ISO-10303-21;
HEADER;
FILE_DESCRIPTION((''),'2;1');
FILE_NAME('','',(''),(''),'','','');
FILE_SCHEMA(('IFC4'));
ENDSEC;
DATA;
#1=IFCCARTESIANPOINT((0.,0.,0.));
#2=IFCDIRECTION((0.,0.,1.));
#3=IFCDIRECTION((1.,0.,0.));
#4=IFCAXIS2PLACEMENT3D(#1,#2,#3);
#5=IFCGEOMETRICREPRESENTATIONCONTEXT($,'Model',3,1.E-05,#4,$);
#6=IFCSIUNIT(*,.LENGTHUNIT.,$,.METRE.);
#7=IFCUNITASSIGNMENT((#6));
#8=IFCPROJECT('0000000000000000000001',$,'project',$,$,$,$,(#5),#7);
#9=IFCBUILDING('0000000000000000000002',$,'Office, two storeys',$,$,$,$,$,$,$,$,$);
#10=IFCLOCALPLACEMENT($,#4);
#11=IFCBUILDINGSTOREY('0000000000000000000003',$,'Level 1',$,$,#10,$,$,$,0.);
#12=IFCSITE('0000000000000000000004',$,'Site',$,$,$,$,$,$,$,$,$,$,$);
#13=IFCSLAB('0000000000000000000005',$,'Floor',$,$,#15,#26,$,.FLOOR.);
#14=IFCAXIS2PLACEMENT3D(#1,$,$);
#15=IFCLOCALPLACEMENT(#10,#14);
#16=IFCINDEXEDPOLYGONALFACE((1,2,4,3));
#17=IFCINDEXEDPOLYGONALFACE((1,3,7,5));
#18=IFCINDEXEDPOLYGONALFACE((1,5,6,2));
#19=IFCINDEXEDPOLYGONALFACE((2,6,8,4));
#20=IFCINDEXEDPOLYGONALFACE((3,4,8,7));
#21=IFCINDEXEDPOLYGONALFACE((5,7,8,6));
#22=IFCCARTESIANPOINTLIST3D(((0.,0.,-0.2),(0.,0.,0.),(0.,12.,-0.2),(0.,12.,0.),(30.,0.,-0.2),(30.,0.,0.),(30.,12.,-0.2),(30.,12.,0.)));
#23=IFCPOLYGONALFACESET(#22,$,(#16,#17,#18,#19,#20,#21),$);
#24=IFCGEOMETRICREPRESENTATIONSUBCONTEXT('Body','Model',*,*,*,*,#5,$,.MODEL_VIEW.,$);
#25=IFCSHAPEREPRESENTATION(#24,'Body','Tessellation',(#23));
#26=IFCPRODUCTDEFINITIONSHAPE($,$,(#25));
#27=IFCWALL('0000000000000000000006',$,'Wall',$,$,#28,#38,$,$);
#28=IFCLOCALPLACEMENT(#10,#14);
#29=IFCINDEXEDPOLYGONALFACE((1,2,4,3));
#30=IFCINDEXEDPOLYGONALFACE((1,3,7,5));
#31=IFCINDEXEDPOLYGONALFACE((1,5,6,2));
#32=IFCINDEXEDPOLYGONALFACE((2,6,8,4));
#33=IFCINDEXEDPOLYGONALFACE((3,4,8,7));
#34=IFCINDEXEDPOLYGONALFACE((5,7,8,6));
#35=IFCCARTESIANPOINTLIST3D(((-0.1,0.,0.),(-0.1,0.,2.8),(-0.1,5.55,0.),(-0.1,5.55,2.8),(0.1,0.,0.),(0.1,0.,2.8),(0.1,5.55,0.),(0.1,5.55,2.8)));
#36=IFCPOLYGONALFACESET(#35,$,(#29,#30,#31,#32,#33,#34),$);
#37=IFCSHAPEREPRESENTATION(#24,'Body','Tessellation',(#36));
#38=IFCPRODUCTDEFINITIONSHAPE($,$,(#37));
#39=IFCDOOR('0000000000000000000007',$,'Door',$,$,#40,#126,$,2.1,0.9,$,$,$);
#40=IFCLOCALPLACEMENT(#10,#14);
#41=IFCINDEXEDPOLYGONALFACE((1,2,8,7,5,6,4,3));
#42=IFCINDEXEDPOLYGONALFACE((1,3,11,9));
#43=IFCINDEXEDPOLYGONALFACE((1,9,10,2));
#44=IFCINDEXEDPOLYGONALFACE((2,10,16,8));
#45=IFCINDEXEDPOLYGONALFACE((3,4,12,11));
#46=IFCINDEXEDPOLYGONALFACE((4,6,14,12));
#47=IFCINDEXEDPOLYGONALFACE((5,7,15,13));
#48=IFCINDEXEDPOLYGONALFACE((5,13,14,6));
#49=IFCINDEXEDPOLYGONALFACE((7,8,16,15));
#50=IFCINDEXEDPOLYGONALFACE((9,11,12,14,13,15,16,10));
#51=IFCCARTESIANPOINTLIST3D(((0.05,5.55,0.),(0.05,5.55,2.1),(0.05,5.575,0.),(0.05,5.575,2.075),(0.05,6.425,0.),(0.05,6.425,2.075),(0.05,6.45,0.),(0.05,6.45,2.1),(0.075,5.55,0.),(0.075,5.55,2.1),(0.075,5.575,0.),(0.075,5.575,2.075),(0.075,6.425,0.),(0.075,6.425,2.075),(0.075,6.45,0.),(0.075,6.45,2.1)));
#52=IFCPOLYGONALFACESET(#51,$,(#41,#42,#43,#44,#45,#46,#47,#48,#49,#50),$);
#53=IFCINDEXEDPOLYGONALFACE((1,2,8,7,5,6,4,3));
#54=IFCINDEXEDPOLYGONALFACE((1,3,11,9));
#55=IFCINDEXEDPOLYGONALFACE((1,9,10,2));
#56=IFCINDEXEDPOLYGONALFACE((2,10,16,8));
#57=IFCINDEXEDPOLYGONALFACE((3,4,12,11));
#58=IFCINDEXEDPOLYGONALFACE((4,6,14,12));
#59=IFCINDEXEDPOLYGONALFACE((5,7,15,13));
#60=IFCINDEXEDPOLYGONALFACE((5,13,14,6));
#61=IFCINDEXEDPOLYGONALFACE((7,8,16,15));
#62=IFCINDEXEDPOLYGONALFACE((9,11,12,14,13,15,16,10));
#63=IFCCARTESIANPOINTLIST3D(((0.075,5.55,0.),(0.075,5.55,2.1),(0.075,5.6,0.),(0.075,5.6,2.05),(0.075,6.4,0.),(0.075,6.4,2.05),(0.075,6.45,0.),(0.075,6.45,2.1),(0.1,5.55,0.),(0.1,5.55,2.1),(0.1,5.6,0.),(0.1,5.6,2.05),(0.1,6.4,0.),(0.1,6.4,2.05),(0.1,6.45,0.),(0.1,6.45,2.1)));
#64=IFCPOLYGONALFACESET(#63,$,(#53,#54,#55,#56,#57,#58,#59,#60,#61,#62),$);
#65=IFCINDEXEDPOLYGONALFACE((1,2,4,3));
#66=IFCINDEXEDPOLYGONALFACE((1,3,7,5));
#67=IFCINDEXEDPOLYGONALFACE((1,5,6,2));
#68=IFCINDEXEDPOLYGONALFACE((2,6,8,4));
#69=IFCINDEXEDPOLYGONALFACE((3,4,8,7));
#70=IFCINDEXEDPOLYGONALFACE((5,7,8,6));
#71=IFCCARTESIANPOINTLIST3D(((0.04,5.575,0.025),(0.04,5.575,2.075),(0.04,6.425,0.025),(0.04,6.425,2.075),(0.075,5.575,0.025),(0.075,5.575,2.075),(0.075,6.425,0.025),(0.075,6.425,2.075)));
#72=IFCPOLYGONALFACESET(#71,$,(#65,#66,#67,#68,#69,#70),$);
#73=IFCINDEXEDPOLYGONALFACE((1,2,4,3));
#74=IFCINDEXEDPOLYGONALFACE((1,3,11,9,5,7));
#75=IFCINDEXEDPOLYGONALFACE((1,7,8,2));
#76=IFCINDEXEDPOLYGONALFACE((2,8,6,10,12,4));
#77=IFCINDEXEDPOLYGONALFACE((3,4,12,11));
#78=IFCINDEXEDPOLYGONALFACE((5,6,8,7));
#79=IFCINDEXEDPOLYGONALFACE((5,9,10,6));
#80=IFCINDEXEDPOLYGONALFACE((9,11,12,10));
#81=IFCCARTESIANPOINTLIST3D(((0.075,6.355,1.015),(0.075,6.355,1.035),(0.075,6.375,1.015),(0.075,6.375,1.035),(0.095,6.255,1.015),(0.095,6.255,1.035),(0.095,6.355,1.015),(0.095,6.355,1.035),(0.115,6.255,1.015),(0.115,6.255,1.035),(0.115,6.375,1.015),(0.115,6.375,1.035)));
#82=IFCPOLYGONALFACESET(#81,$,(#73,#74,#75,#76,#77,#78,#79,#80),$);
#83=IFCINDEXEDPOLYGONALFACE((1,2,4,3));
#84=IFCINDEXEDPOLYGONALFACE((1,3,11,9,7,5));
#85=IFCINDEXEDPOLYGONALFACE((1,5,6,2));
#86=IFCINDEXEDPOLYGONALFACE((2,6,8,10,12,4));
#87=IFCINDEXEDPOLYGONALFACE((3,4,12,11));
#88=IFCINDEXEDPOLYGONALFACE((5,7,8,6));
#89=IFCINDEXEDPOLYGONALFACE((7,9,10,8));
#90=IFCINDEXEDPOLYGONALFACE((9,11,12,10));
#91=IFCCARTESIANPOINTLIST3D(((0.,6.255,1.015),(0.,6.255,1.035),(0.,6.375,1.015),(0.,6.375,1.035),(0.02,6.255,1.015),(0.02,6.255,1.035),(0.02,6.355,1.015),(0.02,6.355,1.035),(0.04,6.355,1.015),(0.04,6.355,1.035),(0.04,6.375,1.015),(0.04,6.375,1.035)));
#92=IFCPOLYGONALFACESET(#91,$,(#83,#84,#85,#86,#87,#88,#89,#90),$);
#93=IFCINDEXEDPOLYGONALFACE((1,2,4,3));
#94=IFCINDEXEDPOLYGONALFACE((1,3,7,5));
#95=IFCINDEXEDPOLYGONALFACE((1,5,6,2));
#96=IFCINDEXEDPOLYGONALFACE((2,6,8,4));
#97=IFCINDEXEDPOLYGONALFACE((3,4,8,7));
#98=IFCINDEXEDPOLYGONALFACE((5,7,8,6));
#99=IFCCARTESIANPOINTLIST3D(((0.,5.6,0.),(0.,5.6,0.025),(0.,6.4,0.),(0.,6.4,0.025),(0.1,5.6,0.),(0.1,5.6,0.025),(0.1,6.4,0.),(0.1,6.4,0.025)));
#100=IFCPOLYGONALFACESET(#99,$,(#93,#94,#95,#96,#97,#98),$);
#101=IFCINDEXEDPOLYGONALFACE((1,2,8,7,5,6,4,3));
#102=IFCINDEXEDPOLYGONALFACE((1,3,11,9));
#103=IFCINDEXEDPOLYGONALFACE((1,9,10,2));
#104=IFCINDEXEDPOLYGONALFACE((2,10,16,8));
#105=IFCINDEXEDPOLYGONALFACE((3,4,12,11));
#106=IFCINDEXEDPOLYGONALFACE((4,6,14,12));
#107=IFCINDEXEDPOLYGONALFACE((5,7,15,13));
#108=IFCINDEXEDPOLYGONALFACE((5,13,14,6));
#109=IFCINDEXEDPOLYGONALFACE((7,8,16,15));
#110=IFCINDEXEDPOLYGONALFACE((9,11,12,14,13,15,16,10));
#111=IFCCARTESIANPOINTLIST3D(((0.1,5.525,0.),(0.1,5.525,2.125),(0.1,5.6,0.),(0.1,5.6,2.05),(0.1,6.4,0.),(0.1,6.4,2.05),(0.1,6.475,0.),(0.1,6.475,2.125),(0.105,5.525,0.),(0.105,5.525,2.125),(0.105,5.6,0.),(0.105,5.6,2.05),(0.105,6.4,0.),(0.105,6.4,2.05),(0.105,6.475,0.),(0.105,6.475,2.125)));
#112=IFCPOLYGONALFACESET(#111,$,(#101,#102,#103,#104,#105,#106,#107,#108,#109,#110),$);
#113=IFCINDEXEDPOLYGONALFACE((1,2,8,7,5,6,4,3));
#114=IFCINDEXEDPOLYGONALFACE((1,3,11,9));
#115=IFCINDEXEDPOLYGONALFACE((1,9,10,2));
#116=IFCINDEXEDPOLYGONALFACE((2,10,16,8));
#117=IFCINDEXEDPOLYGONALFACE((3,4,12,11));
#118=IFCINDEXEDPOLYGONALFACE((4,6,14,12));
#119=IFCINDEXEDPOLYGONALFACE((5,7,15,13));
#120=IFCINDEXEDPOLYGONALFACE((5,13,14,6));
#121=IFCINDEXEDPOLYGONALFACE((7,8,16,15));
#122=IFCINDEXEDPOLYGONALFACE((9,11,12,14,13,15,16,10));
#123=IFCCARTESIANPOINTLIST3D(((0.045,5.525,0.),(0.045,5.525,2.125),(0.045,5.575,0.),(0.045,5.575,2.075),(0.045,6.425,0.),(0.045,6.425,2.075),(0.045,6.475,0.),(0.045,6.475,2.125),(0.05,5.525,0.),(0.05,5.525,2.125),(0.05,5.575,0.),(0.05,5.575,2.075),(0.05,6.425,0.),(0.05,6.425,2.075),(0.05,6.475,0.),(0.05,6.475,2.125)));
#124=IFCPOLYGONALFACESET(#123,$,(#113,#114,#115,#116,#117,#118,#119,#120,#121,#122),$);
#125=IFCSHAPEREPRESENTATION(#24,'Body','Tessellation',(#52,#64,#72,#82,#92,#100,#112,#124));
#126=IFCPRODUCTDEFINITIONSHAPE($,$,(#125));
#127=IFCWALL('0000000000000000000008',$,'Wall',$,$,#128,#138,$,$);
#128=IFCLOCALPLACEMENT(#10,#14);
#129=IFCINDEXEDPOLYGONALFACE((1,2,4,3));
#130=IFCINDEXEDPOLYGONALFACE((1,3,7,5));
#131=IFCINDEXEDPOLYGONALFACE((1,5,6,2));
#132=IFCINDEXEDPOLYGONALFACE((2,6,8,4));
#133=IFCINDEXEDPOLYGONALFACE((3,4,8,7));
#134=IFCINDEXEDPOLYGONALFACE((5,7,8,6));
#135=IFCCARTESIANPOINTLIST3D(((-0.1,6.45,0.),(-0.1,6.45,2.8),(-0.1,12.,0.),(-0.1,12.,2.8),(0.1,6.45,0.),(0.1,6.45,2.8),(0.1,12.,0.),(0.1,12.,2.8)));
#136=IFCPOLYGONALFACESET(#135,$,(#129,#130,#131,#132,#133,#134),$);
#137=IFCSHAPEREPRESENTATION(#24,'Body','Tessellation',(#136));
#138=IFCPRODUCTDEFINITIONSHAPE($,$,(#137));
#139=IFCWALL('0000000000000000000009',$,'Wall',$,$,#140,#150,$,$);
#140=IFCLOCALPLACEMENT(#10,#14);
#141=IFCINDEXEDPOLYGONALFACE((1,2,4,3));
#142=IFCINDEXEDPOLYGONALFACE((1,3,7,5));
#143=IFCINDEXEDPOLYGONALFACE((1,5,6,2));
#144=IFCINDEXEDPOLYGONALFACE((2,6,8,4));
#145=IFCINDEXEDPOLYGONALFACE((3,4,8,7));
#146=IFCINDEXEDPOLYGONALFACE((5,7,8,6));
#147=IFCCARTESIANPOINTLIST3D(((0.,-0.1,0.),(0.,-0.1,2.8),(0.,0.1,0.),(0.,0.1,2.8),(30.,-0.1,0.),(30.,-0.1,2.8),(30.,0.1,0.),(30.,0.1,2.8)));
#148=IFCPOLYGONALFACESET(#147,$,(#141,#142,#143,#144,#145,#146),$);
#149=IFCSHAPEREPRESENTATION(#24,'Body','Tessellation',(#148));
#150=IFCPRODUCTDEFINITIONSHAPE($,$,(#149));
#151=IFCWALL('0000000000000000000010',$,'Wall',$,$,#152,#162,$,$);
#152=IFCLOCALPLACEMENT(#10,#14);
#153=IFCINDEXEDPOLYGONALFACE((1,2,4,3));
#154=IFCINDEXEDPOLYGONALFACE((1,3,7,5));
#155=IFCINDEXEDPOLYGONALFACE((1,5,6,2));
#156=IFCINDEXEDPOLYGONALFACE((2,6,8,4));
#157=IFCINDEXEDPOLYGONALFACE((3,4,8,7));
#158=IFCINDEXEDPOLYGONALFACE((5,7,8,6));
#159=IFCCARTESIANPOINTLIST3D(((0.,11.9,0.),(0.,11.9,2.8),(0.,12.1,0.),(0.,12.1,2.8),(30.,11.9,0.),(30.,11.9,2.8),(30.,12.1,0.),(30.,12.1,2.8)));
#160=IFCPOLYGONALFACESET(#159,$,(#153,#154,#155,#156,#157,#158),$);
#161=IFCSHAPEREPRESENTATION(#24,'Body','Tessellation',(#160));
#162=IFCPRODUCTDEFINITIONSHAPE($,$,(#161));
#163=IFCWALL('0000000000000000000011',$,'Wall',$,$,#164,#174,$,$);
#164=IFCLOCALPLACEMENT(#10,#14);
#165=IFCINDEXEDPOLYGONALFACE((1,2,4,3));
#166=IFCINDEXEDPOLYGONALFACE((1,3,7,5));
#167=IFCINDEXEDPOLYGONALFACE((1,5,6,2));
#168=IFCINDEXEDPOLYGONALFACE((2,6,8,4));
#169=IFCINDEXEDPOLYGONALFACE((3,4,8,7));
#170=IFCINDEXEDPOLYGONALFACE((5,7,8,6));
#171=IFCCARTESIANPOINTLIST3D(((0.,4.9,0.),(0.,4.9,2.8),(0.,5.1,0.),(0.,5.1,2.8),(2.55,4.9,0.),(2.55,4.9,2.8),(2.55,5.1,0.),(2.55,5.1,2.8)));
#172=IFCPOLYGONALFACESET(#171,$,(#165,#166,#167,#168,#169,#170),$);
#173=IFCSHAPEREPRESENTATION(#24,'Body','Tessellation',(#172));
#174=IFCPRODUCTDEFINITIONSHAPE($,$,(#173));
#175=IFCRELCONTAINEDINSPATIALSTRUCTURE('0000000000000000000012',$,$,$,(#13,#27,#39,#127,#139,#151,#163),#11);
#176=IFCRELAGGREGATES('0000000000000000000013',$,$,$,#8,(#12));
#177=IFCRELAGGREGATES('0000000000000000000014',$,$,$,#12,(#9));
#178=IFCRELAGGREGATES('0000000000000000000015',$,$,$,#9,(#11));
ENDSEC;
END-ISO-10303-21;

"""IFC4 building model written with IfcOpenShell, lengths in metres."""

from ifc_helpers import new_model, si_unit, frame, origin_with_axes, place, context, subcontext, project, spatial, line, indexed_curve, outline, extrude, element, save


model = new_model("IFC4")

# Units and contexts
model_context = context("Model", 3, precision=1e-05, world=origin_with_axes())
body_context = subcontext(model_context, "Body", "Model", "MODEL_VIEW")
ifc_project = project(units=[si_unit("LENGTHUNIT", "METRE")], contexts=[model_context])

# Site, building, storey
site = spatial("IfcSite", under=ifc_project, Name="Site")
building = spatial("IfcBuilding", under=site, Name="Office, two storeys")
storey_placement = place(None, origin_with_axes())
storey = spatial("IfcBuildingStorey", under=building, at=storey_placement, Name="Level 1", Elevation=0.0)

# Slab
slab_placement = place(storey_placement, frame((0.0, 0.0, -0.2), z_axis=(0.0, 0.0, 1.0), x_axis=(1.0, 0.0, 0.0)))
element("IfcSlab", 1, at=slab_placement, inside=storey, Name="Floor", PredefinedType="FLOOR", context=body_context, shape_type="SweptSolid", body=[
    extrude(outline(indexed_curve([(0.0, 0.0), (30.0, 0.0), (30.0, 12.0), (0.0, 12.0)])), None, (0.0, 0.0, 1.0), 0.2),
])

# Wall
wall_1_placement = place(storey_placement, frame((0.0, 0.0, 0.0), z_axis=(0.0, 0.0, 1.0), x_axis=(0.0, 1.0, 0.0)))
element("IfcWall", 2, at=wall_1_placement, inside=storey, Name="Wall", context=body_context, shape_type="SweptSolid", body=[
    extrude(outline(indexed_curve([(0.0, 0.0), (0.0, 0.2), (5.55, 0.2), (5.55, 0.0), (0.0, 0.0)], self_intersect=False)), frame((0.0, -0.1, 0.0), z_axis=(0.0, 0.0, 1.0), x_axis=(1.0, 0.0, 0.0)), (0.0, 0.0, 1.0), 2.8),
])

# Door
door_1_placement = place(storey_placement, frame((0.1, 5.55, 0.0), z_axis=(0.0, 0.0, 1.0), x_axis=(0.0, 1.0, 0.0)))
element("IfcDoor", 3, at=door_1_placement, inside=storey, Name="Door", OverallHeight=2.1, OverallWidth=0.9, context=body_context, shape_type="SweptSolid", body=[
    extrude(outline(indexed_curve([(0.0, 0.0), (0.0, 2.1), (0.9, 2.1), (0.9, 0.0), (0.875, 0.0), (0.875, 2.075), (0.025, 2.075), (0.025, 0.0)], segments=[line(1, 2, 3, 4, 5, 6, 7, 8, 1)])), frame((0.0, 0.025, 0.0), z_axis=(0.0, -1.0, 0.0), x_axis=(1.0, 0.0, 0.0)), (0.0, 0.0, -1.0), 0.025),
    extrude(outline(indexed_curve([(0.0, 0.0), (0.0, 2.1), (0.9, 2.1), (0.9, 0.0), (0.85, 0.0), (0.85, 2.05), (0.05, 2.05), (0.05, 0.0)], segments=[line(1, 2, 3, 4, 5, 6, 7, 8, 1)])), frame((0.0, 0.0, 0.0), z_axis=(0.0, -1.0, 0.0), x_axis=(1.0, 0.0, 0.0)), (0.0, 0.0, -1.0), 0.025),
    extrude(outline(indexed_curve([(0.0, 0.0), (0.85, 0.0), (0.85, 0.035), (0.0, 0.035)], segments=[line(1, 2, 3, 4, 1)])), frame((0.025, 0.025, 0.025), z_axis=(0.0, 0.0, 1.0), x_axis=(1.0, 0.0, 0.0)), (0.0, 0.0, 1.0), 2.05),
    extrude(outline(indexed_curve([(0.0, 0.0), (0.0, -0.04), (-0.12, -0.04), (-0.12, -0.02), (-0.02, -0.02), (-0.02, 0.0)], segments=[line(1, 2, 3, 4, 5, 6, 1)])), frame((0.825, 0.025, 1.015), z_axis=(0.0, 0.0, 1.0), x_axis=(1.0, 0.0, 0.0)), (0.0, 0.0, 1.0), 0.02),
    extrude(outline(indexed_curve([(0.0, 0.0), (0.0, 0.04), (-0.12, 0.04), (-0.12, 0.02), (-0.02, 0.02), (-0.02, 0.0)], segments=[line(1, 2, 3, 4, 5, 6, 1)])), frame((0.825, 0.06, 1.015), z_axis=(0.0, 0.0, 1.0), x_axis=(1.0, 0.0, 0.0)), (0.0, 0.0, 1.0), 0.02),
    extrude(outline(indexed_curve([(0.0, 0.0), (0.8, 0.0), (0.8, 0.1), (0.0, 0.1)], segments=[line(1, 2, 3, 4, 1)])), frame((0.05, 0.0, 0.0), z_axis=(0.0, 0.0, 1.0), x_axis=(1.0, 0.0, 0.0)), (0.0, 0.0, 1.0), 0.025),
    extrude(outline(indexed_curve([(0.0, 0.0), (0.0, 2.125), (0.95, 2.125), (0.95, 0.0), (0.875, 0.0), (0.875, 2.05), (0.075, 2.05), (0.075, 0.0)], segments=[line(1, 2, 3, 4, 5, 6, 7, 8, 1)])), frame((-0.025, -0.005, 0.0), z_axis=(0.0, -1.0, 0.0), x_axis=(1.0, 0.0, 0.0)), (0.0, 0.0, -1.0), 0.005),
    extrude(outline(indexed_curve([(0.0, 0.0), (0.0, 2.125), (0.95, 2.125), (0.95, 0.0), (0.9, 0.0), (0.9, 2.075), (0.05, 2.075), (0.05, 0.0)], segments=[line(1, 2, 3, 4, 5, 6, 7, 8, 1)])), frame((-0.025, 0.05, 0.0), z_axis=(0.0, -1.0, 0.0), x_axis=(1.0, 0.0, 0.0)), (0.0, 0.0, -1.0), 0.005),
])

# Walls
wall_2_placement = place(storey_placement, frame((0.0, 6.45, 0.0), z_axis=(0.0, 0.0, 1.0), x_axis=(0.0, 1.0, 0.0)))
element("IfcWall", 4, at=wall_2_placement, inside=storey, Name="Wall", context=body_context, shape_type="SweptSolid", body=[
    extrude(outline(indexed_curve([(0.0, 0.0), (0.0, 0.2), (5.55, 0.2), (5.55, 0.0), (0.0, 0.0)], self_intersect=False)), frame((0.0, -0.1, 0.0), z_axis=(0.0, 0.0, 1.0), x_axis=(1.0, 0.0, 0.0)), (0.0, 0.0, 1.0), 2.8),
])
for number, where, z_axis, x_axis, name in (
    (5, (0.0, 0.0, 0.0), (0.0, 0.0, 1.0), (1.0, 0.0, 0.0), "Wall"),
    (6, (0.0, 12.0, 0.0), (0.0, 0.0, 1.0), (1.0, 0.0, 0.0), "Wall"),
):
    element("IfcWall", number, at=place(storey_placement, frame(where, z_axis=z_axis, x_axis=x_axis)), inside=storey, Name=name, context=body_context, shape_type="SweptSolid", body=[
        extrude(outline(indexed_curve([(0.0, 0.0), (0.0, 0.2), (30.0, 0.2), (30.0, 0.0), (0.0, 0.0)], self_intersect=False)), frame((0.0, -0.1, 0.0), z_axis=(0.0, 0.0, 1.0), x_axis=(1.0, 0.0, 0.0)), (0.0, 0.0, 1.0), 2.8),
    ])
wall_3_placement = place(storey_placement, frame((0.0, 5.0, 0.0), z_axis=(0.0, 0.0, 1.0), x_axis=(1.0, 0.0, 0.0)))
element("IfcWall", 7, at=wall_3_placement, inside=storey, Name="Wall", context=body_context, shape_type="SweptSolid", body=[
    extrude(outline(indexed_curve([(0.0, 0.0), (0.0, 0.2), (2.55, 0.2), (2.55, 0.0), (0.0, 0.0)], self_intersect=False)), frame((0.0, -0.1, 0.0), z_axis=(0.0, 0.0, 1.0), x_axis=(1.0, 0.0, 0.0)), (0.0, 0.0, 1.0), 2.8),
])

save(model, "model.ifc")
